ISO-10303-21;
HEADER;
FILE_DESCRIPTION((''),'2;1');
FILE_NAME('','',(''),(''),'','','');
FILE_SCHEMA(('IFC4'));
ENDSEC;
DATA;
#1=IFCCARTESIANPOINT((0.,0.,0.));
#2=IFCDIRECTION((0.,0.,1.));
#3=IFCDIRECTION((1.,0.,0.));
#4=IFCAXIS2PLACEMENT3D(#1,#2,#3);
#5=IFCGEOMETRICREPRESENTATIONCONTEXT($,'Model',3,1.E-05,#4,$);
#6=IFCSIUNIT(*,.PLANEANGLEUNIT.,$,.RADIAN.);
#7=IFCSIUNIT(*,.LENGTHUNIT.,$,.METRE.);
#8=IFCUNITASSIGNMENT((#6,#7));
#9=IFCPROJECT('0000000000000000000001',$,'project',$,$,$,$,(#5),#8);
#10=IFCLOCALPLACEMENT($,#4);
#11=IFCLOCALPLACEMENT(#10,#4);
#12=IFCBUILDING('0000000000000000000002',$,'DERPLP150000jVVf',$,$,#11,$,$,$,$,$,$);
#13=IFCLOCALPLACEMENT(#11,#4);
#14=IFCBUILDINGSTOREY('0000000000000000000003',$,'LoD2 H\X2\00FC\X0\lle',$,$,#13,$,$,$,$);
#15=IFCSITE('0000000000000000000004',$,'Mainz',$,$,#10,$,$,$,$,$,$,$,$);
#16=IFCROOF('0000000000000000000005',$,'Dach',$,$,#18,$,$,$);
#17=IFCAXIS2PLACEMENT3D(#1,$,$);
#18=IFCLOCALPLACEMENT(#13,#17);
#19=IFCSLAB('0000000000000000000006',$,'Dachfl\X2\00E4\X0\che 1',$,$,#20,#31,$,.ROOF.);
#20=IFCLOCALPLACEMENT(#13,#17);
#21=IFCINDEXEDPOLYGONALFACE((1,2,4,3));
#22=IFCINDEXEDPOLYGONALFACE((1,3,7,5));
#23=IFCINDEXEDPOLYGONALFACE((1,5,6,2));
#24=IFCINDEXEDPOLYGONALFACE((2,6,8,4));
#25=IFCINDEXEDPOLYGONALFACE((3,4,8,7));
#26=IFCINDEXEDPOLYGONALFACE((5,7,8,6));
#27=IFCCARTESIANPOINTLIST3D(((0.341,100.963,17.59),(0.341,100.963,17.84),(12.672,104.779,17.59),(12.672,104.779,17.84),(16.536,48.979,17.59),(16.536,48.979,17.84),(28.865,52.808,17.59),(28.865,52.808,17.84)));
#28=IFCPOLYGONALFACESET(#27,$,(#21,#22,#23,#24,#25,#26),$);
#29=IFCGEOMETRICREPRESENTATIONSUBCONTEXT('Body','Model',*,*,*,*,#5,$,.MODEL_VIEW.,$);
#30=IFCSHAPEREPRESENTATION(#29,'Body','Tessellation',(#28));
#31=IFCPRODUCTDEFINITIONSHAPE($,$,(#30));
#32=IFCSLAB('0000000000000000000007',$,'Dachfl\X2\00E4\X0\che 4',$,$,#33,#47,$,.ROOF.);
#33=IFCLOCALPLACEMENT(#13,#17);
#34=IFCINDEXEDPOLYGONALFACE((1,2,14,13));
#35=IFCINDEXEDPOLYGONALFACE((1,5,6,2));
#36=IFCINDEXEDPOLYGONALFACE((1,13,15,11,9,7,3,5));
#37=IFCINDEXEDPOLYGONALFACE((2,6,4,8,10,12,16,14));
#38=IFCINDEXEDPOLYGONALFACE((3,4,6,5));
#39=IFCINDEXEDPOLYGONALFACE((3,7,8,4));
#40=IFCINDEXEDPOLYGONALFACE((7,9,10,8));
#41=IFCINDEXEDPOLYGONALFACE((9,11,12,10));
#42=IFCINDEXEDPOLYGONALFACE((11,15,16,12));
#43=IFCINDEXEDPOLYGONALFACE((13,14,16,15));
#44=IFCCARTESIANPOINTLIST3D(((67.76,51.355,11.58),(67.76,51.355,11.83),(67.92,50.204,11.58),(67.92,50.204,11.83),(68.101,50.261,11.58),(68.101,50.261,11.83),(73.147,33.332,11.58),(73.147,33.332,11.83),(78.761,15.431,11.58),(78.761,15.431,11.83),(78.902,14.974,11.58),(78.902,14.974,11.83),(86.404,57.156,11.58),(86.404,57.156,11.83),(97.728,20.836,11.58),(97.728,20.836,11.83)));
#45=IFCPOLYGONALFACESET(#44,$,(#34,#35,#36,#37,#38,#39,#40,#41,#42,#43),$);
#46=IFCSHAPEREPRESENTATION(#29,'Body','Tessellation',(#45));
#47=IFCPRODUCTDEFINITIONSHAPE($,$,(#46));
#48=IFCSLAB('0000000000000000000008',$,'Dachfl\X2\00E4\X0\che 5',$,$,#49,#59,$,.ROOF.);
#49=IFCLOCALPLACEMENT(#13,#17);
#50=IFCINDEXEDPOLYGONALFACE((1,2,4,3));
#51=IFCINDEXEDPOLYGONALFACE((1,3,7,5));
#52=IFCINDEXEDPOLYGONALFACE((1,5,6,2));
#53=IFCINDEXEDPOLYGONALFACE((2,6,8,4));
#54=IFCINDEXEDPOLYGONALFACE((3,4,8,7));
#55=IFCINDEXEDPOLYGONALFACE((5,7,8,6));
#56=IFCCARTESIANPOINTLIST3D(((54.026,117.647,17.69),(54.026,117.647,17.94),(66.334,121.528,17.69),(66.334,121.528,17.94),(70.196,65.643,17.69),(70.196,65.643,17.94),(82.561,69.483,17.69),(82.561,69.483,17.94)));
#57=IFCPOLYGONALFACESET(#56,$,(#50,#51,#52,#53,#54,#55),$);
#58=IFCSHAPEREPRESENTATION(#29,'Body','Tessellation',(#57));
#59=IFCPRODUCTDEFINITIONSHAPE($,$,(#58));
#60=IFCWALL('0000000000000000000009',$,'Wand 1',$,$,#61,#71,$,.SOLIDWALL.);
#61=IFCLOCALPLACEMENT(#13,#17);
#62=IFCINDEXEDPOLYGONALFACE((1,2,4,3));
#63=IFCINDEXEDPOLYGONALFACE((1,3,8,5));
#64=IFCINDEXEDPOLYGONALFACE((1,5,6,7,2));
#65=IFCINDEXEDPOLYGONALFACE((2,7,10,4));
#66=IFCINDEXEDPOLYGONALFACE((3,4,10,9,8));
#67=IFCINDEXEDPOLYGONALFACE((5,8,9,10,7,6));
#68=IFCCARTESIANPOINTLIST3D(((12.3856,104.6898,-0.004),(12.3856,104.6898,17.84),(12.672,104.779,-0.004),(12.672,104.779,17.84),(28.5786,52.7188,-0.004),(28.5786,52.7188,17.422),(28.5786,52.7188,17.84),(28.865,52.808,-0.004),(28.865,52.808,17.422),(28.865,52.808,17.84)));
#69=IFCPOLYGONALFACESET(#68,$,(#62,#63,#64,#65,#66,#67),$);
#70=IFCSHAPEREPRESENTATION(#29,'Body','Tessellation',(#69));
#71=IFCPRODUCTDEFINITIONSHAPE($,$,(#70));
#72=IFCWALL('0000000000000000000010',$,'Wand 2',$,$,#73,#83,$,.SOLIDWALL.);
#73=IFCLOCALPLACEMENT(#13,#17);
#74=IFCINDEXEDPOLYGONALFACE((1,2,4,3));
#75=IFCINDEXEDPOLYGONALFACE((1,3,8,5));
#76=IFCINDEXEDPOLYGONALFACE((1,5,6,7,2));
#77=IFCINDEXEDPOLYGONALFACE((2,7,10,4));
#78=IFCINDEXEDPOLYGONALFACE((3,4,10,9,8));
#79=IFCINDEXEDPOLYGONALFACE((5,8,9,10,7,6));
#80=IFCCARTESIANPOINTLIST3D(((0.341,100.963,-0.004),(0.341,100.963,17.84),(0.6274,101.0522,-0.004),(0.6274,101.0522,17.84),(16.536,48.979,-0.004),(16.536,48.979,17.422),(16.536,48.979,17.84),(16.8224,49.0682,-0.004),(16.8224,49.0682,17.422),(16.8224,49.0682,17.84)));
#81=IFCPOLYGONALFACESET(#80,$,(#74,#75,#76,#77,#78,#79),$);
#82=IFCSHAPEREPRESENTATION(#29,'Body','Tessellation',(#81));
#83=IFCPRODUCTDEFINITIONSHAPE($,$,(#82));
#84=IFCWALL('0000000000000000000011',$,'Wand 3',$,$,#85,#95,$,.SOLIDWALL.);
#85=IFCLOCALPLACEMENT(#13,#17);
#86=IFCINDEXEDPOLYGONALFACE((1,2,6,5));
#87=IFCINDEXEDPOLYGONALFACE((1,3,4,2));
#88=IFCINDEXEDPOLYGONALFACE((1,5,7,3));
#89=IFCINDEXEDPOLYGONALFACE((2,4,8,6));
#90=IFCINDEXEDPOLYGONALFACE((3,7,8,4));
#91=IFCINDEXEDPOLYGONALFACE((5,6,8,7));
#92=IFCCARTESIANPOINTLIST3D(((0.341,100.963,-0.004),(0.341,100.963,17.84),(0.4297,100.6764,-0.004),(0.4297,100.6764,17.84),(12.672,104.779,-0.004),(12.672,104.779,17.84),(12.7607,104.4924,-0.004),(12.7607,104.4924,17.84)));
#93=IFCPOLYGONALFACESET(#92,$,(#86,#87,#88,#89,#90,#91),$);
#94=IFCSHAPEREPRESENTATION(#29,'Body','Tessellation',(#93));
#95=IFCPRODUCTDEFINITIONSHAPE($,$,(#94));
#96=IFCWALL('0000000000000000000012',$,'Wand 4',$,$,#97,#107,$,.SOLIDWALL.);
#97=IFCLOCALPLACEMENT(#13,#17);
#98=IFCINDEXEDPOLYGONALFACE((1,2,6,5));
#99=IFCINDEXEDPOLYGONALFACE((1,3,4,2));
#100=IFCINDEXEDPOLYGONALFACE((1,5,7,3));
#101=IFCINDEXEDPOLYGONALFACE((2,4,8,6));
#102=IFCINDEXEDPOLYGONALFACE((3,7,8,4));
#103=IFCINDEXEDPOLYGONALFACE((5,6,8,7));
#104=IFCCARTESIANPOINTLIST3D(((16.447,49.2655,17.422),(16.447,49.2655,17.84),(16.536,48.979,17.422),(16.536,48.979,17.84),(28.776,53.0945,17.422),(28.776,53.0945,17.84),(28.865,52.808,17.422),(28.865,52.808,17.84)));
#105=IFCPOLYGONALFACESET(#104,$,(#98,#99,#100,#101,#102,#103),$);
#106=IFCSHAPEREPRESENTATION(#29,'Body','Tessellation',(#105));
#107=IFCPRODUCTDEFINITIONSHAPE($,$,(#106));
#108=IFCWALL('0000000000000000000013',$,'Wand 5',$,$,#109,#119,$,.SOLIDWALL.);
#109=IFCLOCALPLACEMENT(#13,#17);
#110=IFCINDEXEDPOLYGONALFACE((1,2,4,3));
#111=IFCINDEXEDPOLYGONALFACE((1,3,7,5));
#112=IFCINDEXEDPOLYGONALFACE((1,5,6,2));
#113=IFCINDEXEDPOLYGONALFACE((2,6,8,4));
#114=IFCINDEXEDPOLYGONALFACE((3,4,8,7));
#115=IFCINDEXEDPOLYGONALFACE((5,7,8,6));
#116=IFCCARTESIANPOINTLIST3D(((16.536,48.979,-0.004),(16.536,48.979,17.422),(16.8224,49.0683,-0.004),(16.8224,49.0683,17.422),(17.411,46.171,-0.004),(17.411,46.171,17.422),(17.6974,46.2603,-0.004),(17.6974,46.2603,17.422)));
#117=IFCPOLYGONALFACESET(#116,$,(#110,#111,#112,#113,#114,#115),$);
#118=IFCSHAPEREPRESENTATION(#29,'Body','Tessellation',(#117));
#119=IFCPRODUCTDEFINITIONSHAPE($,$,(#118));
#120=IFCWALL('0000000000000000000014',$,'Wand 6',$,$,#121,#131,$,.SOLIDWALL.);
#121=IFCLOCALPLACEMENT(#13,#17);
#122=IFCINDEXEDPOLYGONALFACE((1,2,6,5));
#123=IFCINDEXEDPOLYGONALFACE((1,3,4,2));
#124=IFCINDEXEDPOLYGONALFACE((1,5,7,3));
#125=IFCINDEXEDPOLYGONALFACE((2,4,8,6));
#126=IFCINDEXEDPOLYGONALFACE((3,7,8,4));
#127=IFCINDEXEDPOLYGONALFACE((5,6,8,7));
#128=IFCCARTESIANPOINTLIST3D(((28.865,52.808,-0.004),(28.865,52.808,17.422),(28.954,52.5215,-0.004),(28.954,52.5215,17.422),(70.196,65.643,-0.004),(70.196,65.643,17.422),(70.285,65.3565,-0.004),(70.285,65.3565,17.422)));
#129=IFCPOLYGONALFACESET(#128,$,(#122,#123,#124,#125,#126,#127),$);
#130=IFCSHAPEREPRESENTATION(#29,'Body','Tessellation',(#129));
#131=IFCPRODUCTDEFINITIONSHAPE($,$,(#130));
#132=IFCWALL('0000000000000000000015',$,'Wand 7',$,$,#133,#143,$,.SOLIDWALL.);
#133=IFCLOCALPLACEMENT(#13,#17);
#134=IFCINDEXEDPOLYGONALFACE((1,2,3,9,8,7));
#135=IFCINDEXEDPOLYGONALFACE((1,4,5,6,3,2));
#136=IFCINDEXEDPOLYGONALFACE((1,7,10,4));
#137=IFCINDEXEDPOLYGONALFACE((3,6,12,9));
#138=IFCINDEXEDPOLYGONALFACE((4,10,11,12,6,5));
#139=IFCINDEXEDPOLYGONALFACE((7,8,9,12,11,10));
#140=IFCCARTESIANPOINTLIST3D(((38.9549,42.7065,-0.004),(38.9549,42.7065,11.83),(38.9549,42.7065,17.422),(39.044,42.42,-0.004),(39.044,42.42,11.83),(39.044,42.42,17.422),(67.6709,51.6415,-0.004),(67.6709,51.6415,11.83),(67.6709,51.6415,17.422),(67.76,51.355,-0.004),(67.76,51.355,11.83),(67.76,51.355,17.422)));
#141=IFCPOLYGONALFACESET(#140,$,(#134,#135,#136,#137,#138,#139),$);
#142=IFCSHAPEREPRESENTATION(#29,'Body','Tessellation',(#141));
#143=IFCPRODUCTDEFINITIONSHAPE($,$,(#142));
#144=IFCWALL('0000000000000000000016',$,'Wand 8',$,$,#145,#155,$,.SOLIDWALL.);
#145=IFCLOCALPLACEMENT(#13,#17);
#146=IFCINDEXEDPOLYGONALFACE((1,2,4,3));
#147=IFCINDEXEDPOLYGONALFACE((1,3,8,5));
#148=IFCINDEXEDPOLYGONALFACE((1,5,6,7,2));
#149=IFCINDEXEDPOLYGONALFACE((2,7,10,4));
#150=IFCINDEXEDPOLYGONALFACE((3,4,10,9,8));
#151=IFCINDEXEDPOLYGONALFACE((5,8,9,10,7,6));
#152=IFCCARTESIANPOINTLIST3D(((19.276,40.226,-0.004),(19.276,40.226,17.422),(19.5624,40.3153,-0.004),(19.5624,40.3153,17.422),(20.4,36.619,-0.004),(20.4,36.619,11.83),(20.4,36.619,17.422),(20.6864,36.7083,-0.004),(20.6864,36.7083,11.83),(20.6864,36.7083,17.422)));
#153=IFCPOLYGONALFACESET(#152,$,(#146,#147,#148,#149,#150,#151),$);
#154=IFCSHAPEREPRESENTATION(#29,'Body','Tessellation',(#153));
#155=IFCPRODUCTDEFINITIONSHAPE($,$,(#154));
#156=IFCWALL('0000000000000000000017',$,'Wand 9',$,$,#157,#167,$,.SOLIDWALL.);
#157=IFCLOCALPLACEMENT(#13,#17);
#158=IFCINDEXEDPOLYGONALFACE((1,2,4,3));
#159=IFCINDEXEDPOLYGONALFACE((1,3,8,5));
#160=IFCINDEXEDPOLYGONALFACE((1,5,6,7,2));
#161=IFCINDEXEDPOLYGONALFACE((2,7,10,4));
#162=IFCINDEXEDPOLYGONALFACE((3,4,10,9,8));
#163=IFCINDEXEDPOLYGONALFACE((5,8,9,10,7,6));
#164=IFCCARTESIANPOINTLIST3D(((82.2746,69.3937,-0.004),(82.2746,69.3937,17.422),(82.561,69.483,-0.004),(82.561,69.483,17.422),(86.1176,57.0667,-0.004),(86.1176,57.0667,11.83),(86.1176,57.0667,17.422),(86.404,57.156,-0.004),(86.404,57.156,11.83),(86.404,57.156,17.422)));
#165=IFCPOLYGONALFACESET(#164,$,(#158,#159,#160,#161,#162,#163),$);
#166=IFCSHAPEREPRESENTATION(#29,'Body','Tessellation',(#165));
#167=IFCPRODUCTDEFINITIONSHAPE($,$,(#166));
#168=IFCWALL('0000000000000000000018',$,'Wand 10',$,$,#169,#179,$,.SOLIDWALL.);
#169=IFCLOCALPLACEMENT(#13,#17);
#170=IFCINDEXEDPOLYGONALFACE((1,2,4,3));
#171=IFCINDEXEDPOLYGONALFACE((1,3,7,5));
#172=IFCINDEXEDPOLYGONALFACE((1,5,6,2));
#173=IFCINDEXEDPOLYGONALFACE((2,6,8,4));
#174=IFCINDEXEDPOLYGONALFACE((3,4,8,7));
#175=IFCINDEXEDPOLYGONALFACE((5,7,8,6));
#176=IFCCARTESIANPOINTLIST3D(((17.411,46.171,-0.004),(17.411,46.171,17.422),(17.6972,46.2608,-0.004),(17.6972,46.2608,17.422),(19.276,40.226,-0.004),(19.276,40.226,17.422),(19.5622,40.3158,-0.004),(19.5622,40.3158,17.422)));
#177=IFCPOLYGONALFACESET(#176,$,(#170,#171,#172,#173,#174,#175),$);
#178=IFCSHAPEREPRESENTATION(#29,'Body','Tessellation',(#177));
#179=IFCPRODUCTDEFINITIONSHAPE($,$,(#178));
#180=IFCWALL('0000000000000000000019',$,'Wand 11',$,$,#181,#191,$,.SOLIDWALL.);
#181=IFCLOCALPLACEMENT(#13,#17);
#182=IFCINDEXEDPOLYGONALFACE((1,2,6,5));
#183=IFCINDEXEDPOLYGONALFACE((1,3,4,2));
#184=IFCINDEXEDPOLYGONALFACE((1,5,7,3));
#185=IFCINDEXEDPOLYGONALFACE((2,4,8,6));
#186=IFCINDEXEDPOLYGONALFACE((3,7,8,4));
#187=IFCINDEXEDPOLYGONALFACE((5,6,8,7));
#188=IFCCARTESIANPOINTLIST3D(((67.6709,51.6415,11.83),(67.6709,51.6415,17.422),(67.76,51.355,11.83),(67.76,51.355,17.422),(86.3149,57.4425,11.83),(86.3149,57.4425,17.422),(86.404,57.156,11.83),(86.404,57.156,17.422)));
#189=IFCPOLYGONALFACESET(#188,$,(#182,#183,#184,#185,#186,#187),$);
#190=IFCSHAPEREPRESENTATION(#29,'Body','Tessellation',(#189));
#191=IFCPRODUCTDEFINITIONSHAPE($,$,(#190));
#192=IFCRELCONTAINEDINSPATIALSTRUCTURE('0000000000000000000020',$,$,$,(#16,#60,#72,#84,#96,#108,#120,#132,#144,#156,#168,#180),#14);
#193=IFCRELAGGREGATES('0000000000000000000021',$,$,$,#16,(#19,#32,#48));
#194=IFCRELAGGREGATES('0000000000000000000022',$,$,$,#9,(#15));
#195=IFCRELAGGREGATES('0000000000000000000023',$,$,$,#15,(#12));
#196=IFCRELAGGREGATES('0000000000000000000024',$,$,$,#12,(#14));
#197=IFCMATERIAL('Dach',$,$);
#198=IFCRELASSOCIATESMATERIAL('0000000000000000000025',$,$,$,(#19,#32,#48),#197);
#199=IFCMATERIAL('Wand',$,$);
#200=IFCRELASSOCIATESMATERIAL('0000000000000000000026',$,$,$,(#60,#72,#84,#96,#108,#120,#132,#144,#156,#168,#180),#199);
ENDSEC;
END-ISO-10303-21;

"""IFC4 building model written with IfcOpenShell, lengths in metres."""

from ifc_helpers import new_model, si_unit, frame, origin_with_axes, place, context, subcontext, project, spatial, polyline, outline, extrude, material, element, aggregate, save


model = new_model("IFC4")

# Units and contexts
model_context = context("Model", 3, precision=1e-05, world=origin_with_axes())
body_context = subcontext(model_context, "Body", "Model", "MODEL_VIEW")
ifc_project = project(units=[si_unit("PLANEANGLEUNIT", "RADIAN"), si_unit("LENGTHUNIT", "METRE")], contexts=[model_context])

# Site, building, storey
site_placement = place(None, origin_with_axes())
site = spatial("IfcSite", under=ifc_project, at=site_placement, Name="Mainz")
building_placement = place(site_placement, origin_with_axes())
building = spatial("IfcBuilding", under=site, at=building_placement, Name="DERPLP150000jVVf")
storey_placement = place(building_placement, origin_with_axes())
storey = spatial("IfcBuildingStorey", under=building, at=storey_placement, Name="LoD2 Hülle")

# Roof, slabs
roof_placement = place(storey_placement, origin_with_axes())
roof = element("IfcRoof", 1, at=roof_placement, inside=storey, Name="Dach")
ifc_material_1 = material(Name="Dach")
slab_1_placement = place(roof_placement, origin_with_axes())
slab_1 = element("IfcSlab", 2, at=slab_1_placement, material=ifc_material_1, Name="Dachfläche 1", PredefinedType="ROOF", context=body_context, shape_type="SweptSolid", body=[
    extrude(outline(polyline([(0.0, 0.0), (54.4483, 0.0), (54.4597, 12.9099), (0.0244, 12.9079), (0.0, 0.0)])), frame((0.341, 100.963, 17.84), z_axis=(0.0, 0.0, 1.0), x_axis=(0.297438, -0.954741, 0.0)), (0.0, 0.0, -1.0), 0.25),
])
slab_2_placement = place(roof_placement, origin_with_axes())
slab_2 = element("IfcSlab", 3, at=slab_2_placement, material=ifc_material_1, Name="Dachfläche 4", PredefinedType="ROOF", context=body_context, shape_type="SweptSolid", body=[
    extrude(outline(polyline([(0.0, 0.0), (38.0444, 0.0), (38.0558, 19.5256), (36.9098, 19.5257), (36.9093, 19.7155), (19.2462, 19.7474), (0.4856, 19.7161), (0.0073, 19.7175), (0.0, 0.0)])), frame((97.728, 20.836, 11.83), z_axis=(0.0, 0.0, 1.0), x_axis=(-0.297652, 0.954674, 0.0)), (0.0, 0.0, -1.0), 0.25),
])
slab_3_placement = place(roof_placement, origin_with_axes())
slab_3 = element("IfcSlab", 4, at=slab_3_placement, material=ifc_material_1, Name="Dachfläche 5", PredefinedType="ROOF", context=body_context, shape_type="SweptSolid", body=[
    extrude(outline(polyline([(0.0, 0.0), (54.516, 0.0), (54.4745, 12.9053), (0.0146, 12.9475), (0.0, 0.0)])), frame((82.561, 69.483, 17.94), z_axis=(0.0, 0.0, 1.0), x_axis=(-0.297656, 0.954673, 0.0)), (0.0, 0.0, -1.0), 0.25),
])
aggregate(roof, [slab_1, slab_2, slab_3])

# Walls
ifc_material_2 = material(Name="Wand")
wall_1_placement = place(storey_placement, origin_with_axes())
element("IfcWall", 5, at=wall_1_placement, inside=storey, material=ifc_material_2, Name="Wand 1", PredefinedType="SOLIDWALL", context=body_context, shape_type="SweptSolid", body=[
    extrude(outline(polyline([(0.0, 0.0), (54.4353, 0.0), (54.4353, 0.418), (54.4353, 17.844), (0.0, 17.844), (0.0, 0.0)])), frame((12.672, 104.779, 17.84), z_axis=(0.95473, 0.297473, 0.0), x_axis=(0.297473, -0.95473, 0.0)), (0.0, 0.0, -1.0), 0.3),
])
wall_2_placement = place(storey_placement, origin_with_axes())
element("IfcWall", 6, at=wall_2_placement, inside=storey, material=ifc_material_2, Name="Wand 2", PredefinedType="SOLIDWALL", context=body_context, shape_type="SweptSolid", body=[
    extrude(outline(polyline([(0.0, 0.0), (54.4483, 0.0), (54.4483, 17.844), (0.0, 17.844), (0.0, 0.418), (0.0, 0.0)])), frame((16.536, 48.979, 17.84), z_axis=(-0.954741, -0.297438, 0.0), x_axis=(-0.297438, 0.954741, 0.0)), (0.0, 0.0, -1.0), 0.3),
])
wall_3_placement = place(storey_placement, origin_with_axes())
element("IfcWall", 7, at=wall_3_placement, inside=storey, material=ifc_material_2, Name="Wand 3", PredefinedType="SOLIDWALL", context=body_context, shape_type="SweptSolid", body=[
    extrude(outline(polyline([(0.0, 0.0), (12.908, 0.0), (12.908, 17.844), (0.0, 17.844), (0.0, 0.0)])), frame((0.341, 100.963, 17.84), z_axis=(-0.295632, 0.955302, 0.0), x_axis=(0.955302, 0.295632, 0.0)), (0.0, 0.0, -1.0), 0.3),
])
wall_4_placement = place(storey_placement, origin_with_axes())
element("IfcWall", 8, at=wall_4_placement, inside=storey, material=ifc_material_2, Name="Wand 4", PredefinedType="SOLIDWALL", context=body_context, shape_type="SweptSolid", body=[
    extrude(outline(polyline([(0.0, 0.0), (12.9099, 0.0), (12.9099, 0.418), (0.0, 0.418), (0.0, 0.0)])), frame((16.536, 48.979, 17.422), z_axis=(0.296594, -0.955004, 0.0), x_axis=(0.955004, 0.296594, 0.0)), (0.0, 0.0, -1.0), 0.3),
])
wall_5_placement = place(storey_placement, origin_with_axes())
element("IfcWall", 9, at=wall_5_placement, inside=storey, material=ifc_material_2, Name="Wand 5", PredefinedType="SOLIDWALL", context=body_context, shape_type="SweptSolid", body=[
    extrude(outline(polyline([(0.0, 0.0), (2.9412, 0.0), (2.9412, 17.426), (0.0, 17.426), (0.0, 0.0)])), frame((17.411, 46.171, 17.422), z_axis=(-0.954722, -0.297501, 0.0), x_axis=(-0.297501, 0.954722, 0.0)), (0.0, 0.0, -1.0), 0.3),
])
wall_6_placement = place(storey_placement, origin_with_axes())
element("IfcWall", 10, at=wall_6_placement, inside=storey, material=ifc_material_2, Name="Wand 6", PredefinedType="SOLIDWALL", context=body_context, shape_type="SweptSolid", body=[
    extrude(outline(polyline([(0.0, 0.0), (43.278, 0.0), (43.278, 17.426), (0.0, 17.426), (0.0, 0.0)])), frame((28.865, 52.808, 17.422), z_axis=(-0.296571, 0.955011, 0.0), x_axis=(0.955011, 0.296571, 0.0)), (0.0, 0.0, -1.0), 0.3),
])
wall_7_placement = place(storey_placement, origin_with_axes())
element("IfcWall", 11, at=wall_7_placement, inside=storey, material=ifc_material_2, Name="Wand 7", PredefinedType="SOLIDWALL", context=body_context, shape_type="SweptSolid", body=[
    extrude(outline(polyline([(0.0, 0.0), (30.074, 0.0), (30.074, 5.592), (30.074, 17.426), (0.0, 17.426), (0.0, 5.592), (0.0, 0.0)])), frame((67.76, 51.355, 17.422), z_axis=(0.297101, -0.954846, 0.0), x_axis=(-0.954846, -0.297101, 0.0)), (0.0, 0.0, -1.0), 0.3),
])
wall_8_placement = place(storey_placement, origin_with_axes())
element("IfcWall", 12, at=wall_8_placement, inside=storey, material=ifc_material_2, Name="Wand 8", PredefinedType="SOLIDWALL", context=body_context, shape_type="SweptSolid", body=[
    extrude(outline(polyline([(0.0, 0.0), (3.7781, 0.0), (3.7781, 17.426), (0.0, 17.426), (0.0, 5.592), (0.0, 0.0)])), frame((20.4, 36.619, 17.422), z_axis=(-0.95472, -0.297506, 0.0), x_axis=(-0.297506, 0.95472, 0.0)), (0.0, 0.0, -1.0), 0.3),
])
wall_9_placement = place(storey_placement, origin_with_axes())
element("IfcWall", 13, at=wall_9_placement, inside=storey, material=ifc_material_2, Name="Wand 9", PredefinedType="SOLIDWALL", context=body_context, shape_type="SweptSolid", body=[
    extrude(outline(polyline([(0.0, 0.0), (12.9121, 0.0), (12.9121, 5.592), (12.9121, 17.426), (0.0, 17.426), (0.0, 0.0)])), frame((82.561, 69.483, 17.422), z_axis=(0.954682, 0.297627, 0.0), x_axis=(0.297627, -0.954682, 0.0)), (0.0, 0.0, -1.0), 0.3),
])
wall_10_placement = place(storey_placement, origin_with_axes())
element("IfcWall", 14, at=wall_10_placement, inside=storey, material=ifc_material_2, Name="Wand 10", PredefinedType="SOLIDWALL", context=body_context, shape_type="SweptSolid", body=[
    extrude(outline(polyline([(0.0, 0.0), (6.2307, 0.0), (6.2307, 17.426), (0.0, 17.426), (0.0, 0.0)])), frame((19.276, 40.226, 17.422), z_axis=(-0.954151, -0.299326, 0.0), x_axis=(-0.299326, 0.954151, 0.0)), (0.0, 0.0, -1.0), 0.3),
])
wall_11_placement = place(storey_placement, origin_with_axes())
element("IfcWall", 15, at=wall_11_placement, inside=storey, material=ifc_material_2, Name="Wand 11", PredefinedType="SOLIDWALL", context=body_context, shape_type="SweptSolid", body=[
    extrude(outline(polyline([(0.0, 0.0), (19.5256, 0.0), (19.5256, 5.592), (0.0, 5.592), (0.0, 0.0)])), frame((67.76, 51.355, 11.83), z_axis=(0.297097, -0.954847, 0.0), x_axis=(0.954847, 0.297097, 0.0)), (0.0, 0.0, -1.0), 0.3),
])

save(model, "model.ifc")
